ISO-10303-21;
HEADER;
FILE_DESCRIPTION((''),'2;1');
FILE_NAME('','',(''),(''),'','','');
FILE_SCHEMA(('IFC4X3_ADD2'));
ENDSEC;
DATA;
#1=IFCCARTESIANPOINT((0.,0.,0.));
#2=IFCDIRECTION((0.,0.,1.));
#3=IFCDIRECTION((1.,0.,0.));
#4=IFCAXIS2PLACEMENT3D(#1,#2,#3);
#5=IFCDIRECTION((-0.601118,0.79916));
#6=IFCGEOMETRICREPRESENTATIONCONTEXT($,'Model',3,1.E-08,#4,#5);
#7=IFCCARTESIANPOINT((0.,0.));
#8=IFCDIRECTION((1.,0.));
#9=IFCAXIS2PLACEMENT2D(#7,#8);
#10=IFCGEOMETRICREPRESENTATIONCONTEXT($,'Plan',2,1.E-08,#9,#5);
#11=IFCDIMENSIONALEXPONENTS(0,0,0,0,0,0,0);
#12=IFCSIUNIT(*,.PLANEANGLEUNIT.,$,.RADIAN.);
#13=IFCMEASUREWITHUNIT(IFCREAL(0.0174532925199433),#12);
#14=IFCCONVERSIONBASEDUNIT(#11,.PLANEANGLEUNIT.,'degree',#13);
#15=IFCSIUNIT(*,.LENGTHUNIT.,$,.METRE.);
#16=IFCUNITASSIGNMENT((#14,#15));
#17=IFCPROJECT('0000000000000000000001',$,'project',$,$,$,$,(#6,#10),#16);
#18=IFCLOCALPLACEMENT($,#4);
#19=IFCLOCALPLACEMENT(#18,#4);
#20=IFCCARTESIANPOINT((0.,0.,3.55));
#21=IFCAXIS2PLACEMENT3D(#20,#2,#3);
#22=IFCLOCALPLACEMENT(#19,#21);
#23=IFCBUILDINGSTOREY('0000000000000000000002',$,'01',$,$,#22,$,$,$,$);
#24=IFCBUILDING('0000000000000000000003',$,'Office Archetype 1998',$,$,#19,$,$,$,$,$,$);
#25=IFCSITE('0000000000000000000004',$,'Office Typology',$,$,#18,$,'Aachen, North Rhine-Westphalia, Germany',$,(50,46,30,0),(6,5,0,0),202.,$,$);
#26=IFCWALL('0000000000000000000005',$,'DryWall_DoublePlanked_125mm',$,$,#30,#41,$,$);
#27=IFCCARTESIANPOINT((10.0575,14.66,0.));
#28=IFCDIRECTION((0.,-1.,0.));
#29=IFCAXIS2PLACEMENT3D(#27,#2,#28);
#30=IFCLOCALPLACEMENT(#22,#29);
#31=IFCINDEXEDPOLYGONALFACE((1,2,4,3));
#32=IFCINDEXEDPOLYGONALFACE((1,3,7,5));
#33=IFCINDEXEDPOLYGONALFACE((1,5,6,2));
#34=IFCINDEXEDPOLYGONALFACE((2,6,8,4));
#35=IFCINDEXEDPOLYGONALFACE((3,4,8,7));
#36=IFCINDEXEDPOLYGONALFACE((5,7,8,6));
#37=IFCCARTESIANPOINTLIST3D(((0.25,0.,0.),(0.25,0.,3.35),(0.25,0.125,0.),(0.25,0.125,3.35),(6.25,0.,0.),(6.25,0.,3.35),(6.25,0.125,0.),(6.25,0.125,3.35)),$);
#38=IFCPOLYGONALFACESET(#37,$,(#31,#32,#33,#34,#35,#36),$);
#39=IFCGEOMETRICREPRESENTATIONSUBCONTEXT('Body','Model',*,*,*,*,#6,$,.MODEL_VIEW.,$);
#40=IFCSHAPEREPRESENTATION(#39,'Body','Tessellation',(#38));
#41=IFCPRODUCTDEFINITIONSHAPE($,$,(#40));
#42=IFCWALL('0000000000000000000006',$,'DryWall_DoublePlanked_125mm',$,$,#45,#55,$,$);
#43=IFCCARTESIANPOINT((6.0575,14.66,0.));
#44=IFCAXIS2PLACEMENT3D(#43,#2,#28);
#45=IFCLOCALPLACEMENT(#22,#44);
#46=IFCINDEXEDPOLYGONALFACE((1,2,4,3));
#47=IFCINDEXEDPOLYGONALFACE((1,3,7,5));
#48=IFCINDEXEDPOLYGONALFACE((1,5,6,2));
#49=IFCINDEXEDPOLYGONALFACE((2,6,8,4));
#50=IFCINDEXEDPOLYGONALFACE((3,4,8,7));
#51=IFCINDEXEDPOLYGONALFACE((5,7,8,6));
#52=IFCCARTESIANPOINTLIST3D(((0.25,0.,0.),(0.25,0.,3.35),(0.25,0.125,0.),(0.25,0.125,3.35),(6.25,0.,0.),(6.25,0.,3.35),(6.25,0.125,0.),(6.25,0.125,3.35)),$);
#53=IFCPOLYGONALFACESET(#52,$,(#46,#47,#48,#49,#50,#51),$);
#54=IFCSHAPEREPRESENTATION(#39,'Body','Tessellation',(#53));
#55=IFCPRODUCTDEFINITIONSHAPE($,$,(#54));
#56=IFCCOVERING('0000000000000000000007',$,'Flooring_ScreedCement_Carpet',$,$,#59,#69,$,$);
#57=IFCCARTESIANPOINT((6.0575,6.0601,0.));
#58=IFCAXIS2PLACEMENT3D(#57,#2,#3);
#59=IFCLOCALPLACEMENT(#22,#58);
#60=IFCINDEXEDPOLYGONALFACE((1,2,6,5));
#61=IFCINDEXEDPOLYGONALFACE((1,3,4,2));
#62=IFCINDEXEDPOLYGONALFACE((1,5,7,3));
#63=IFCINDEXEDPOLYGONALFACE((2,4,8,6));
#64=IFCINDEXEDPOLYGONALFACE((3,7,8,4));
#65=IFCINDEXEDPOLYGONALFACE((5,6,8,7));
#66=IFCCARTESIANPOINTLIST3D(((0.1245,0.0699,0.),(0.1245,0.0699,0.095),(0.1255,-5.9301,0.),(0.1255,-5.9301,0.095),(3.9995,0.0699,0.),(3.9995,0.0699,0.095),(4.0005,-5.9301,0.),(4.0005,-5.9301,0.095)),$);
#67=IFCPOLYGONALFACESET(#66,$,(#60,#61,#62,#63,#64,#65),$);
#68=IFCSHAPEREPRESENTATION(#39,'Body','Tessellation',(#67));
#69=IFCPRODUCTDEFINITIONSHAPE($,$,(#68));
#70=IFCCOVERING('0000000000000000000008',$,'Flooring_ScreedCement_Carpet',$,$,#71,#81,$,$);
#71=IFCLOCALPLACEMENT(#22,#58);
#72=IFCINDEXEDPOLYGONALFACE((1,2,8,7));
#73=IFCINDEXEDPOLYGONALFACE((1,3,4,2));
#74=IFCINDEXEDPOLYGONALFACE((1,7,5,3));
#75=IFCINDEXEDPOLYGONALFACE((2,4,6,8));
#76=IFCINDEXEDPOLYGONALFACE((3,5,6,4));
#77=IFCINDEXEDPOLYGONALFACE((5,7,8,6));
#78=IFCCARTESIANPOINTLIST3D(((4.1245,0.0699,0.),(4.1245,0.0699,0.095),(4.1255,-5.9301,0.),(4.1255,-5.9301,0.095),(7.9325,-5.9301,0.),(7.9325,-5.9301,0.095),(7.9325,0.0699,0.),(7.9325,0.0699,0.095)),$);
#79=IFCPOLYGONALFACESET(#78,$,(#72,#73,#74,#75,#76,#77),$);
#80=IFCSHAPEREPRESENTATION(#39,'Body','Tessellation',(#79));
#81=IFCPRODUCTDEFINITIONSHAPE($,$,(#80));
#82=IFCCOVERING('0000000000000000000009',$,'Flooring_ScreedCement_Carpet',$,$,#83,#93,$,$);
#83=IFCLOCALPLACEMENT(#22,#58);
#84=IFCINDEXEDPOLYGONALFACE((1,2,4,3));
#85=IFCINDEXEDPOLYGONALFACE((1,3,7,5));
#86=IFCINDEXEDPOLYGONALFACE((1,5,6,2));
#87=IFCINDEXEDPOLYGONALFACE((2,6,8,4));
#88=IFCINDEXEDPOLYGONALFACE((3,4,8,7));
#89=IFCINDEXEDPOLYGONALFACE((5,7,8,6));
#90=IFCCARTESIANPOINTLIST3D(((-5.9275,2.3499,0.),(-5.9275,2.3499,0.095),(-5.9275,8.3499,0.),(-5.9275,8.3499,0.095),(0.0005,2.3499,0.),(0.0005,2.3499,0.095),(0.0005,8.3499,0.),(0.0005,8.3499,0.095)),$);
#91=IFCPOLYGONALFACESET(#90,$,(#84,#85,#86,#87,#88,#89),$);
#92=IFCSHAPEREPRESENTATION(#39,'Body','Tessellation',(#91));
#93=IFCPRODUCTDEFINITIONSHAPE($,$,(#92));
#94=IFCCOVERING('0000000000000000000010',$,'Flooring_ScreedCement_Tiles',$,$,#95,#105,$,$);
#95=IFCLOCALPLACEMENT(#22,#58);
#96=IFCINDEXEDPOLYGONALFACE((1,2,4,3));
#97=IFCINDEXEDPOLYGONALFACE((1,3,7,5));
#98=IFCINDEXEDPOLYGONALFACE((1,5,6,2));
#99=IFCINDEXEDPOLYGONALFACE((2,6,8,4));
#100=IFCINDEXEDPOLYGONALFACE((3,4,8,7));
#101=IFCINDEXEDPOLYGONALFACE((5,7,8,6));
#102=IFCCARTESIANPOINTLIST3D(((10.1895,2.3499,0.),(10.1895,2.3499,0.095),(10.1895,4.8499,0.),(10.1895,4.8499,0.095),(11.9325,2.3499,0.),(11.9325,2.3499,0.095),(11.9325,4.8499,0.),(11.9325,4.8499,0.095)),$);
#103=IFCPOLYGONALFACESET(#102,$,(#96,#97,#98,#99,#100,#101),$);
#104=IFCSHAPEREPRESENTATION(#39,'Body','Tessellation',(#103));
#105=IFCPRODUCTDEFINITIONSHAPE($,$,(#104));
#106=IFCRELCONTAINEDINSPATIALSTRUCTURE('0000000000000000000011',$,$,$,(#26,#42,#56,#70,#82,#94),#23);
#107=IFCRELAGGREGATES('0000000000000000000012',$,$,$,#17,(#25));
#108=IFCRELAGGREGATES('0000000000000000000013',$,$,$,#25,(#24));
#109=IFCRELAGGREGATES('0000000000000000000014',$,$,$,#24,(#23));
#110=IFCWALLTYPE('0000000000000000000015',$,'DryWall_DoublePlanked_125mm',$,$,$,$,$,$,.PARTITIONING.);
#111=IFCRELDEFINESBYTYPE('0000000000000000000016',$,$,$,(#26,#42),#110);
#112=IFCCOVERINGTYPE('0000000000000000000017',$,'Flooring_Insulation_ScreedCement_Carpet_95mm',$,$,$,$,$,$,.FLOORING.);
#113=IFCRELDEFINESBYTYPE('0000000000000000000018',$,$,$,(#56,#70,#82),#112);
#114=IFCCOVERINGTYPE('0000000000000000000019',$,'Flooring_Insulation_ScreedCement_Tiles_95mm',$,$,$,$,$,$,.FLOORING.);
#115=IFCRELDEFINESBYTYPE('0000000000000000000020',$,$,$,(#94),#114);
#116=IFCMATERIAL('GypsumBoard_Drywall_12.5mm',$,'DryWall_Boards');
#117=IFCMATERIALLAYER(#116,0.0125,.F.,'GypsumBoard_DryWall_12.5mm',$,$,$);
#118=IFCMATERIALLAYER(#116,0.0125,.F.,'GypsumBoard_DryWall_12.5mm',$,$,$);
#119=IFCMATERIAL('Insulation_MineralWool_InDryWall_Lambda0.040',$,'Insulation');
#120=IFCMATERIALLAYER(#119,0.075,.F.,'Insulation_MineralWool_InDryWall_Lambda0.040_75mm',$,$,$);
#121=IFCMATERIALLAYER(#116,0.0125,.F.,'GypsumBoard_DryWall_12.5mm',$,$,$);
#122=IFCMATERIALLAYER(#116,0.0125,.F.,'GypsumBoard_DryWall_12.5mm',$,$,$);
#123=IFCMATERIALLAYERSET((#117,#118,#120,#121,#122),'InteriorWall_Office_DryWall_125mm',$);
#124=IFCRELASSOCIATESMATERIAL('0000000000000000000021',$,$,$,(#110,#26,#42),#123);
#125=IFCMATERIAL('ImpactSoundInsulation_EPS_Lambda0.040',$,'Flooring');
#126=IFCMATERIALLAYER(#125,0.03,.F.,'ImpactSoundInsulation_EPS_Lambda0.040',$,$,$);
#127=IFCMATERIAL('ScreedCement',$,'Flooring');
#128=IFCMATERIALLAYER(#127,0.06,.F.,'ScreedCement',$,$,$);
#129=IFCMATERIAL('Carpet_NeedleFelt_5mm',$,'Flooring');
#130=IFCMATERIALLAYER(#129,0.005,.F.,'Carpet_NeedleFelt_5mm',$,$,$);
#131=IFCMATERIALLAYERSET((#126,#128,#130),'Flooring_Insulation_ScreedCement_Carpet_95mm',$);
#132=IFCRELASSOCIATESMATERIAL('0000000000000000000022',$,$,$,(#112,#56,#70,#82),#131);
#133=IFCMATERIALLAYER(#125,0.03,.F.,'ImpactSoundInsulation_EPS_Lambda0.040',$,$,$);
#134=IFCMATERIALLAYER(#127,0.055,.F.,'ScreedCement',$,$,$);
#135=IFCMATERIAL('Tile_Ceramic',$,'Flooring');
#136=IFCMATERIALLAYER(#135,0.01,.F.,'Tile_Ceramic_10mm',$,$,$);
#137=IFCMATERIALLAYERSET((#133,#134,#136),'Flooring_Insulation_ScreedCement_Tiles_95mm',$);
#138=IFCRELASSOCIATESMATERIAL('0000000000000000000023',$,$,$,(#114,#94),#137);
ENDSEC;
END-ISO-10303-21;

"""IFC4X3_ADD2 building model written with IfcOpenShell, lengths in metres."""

from ifc_helpers import new_model, entity, si_unit, converted_unit, direction, frame, origin_with_axes, origin_2d_with_axis, place, context, subcontext, project, spatial, line, indexed_curve, outline, extrude, material, layer, layer_set, layer_usage, type_object, element, save


model = new_model("IFC4X3_ADD2")

# Units and contexts
model_context = context("Model", 3, precision=1e-08, world=origin_with_axes(), true_north=direction((-0.601118, 0.79916)))
plan_context = context("Plan", 2, precision=1e-08, world=origin_2d_with_axis(), true_north=direction((-0.601118, 0.79916)))
body_context = subcontext(model_context, "Body", "Model", "MODEL_VIEW")
ifc_project = project(units=[converted_unit("PLANEANGLEUNIT", "degree", entity("IfcReal", 0.0174532925199433), si_unit("PLANEANGLEUNIT", "RADIAN"), dimensions=[0, 0, 0, 0, 0, 0, 0]), si_unit("LENGTHUNIT", "METRE")], contexts=[model_context, plan_context])

# Site, building, storey
site_placement = place(None, origin_with_axes())
site = spatial("IfcSite", under=ifc_project, at=site_placement, Name="Office Typology", LongName="Aachen, North Rhine-Westphalia, Germany", RefLatitude=(50, 46, 30, 0), RefLongitude=(6, 5, 0, 0), RefElevation=202.0)
building_placement = place(site_placement, origin_with_axes())
building = spatial("IfcBuilding", under=site, at=building_placement, Name="Office Archetype 1998")
storey_placement = place(building_placement, frame((0.0, 0.0, 3.55), z_axis=(0.0, 0.0, 1.0), x_axis=(1.0, 0.0, 0.0)))
storey = spatial("IfcBuildingStorey", under=building, at=storey_placement, Name="01")

# Walls
ifc_material_1 = material(Name="GypsumBoard_Drywall_12.5mm", Category="DryWall_Boards")
ifc_layer_1 = layer(ifc_material_1, 0.0125, ventilated=False, Name="GypsumBoard_DryWall_12.5mm")
ifc_layer_2 = layer(ifc_material_1, 0.0125, ventilated=False, Name="GypsumBoard_DryWall_12.5mm")
ifc_material_2 = material(Name="Insulation_MineralWool_InDryWall_Lambda0.040", Category="Insulation")
ifc_layer_3 = layer(ifc_material_2, 0.075, ventilated=False, Name="Insulation_MineralWool_InDryWall_Lambda0.040_75mm")
ifc_layer_4 = layer(ifc_material_1, 0.0125, ventilated=False, Name="GypsumBoard_DryWall_12.5mm")
ifc_layer_5 = layer(ifc_material_1, 0.0125, ventilated=False, Name="GypsumBoard_DryWall_12.5mm")
ifc_layer_set_1 = layer_set([ifc_layer_1, ifc_layer_2, ifc_layer_3, ifc_layer_4, ifc_layer_5], Name="InteriorWall_Office_DryWall_125mm")
ifc_layer_usage_1 = layer_usage(ifc_layer_set_1, "AXIS2", "POSITIVE", 0.0)
wall_type_1 = type_object("IfcWallType", Name="DryWall_DoublePlanked_125mm", PredefinedType="PARTITIONING", material=ifc_layer_set_1)
wall_1_placement = place(storey_placement, frame((10.0575, 14.66, 0.0), z_axis=(0.0, 0.0, 1.0), x_axis=(0.0, -1.0, 0.0)))
element("IfcWall", 1, at=wall_1_placement, inside=storey, type_object=wall_type_1, material=ifc_layer_usage_1, Name="DryWall_DoublePlanked_125mm", context=body_context, shape_type="SweptSolid", body=[
    extrude(outline(indexed_curve([(0.25, 0.0), (0.25, 0.125), (6.25, 0.125), (6.25, 0.0)], segments=[line(1, 2, 3, 4, 1)])), origin_with_axes(), (0.0, 0.0, 1.0), 3.35),
])
ifc_layer_usage_2 = layer_usage(ifc_layer_set_1, "AXIS2", "POSITIVE", 0.0)
wall_2_placement = place(storey_placement, frame((6.0575, 14.66, 0.0), z_axis=(0.0, 0.0, 1.0), x_axis=(0.0, -1.0, 0.0)))
element("IfcWall", 2, at=wall_2_placement, inside=storey, type_object=wall_type_1, material=ifc_layer_usage_2, Name="DryWall_DoublePlanked_125mm", context=body_context, shape_type="SweptSolid", body=[
    extrude(outline(indexed_curve([(0.25, 0.0), (0.25, 0.125), (6.25, 0.125), (6.25, 0.0)], segments=[line(1, 2, 3, 4, 1)])), origin_with_axes(), (0.0, 0.0, 1.0), 3.35),
])

# Coverings
ifc_material_3 = material(Name="ImpactSoundInsulation_EPS_Lambda0.040", Category="Flooring")
ifc_layer_6 = layer(ifc_material_3, 0.03, ventilated=False, Name="ImpactSoundInsulation_EPS_Lambda0.040")
ifc_material_4 = material(Name="ScreedCement", Category="Flooring")
ifc_layer_7 = layer(ifc_material_4, 0.06, ventilated=False, Name="ScreedCement")
ifc_material_5 = material(Name="Carpet_NeedleFelt_5mm", Category="Flooring")
ifc_layer_8 = layer(ifc_material_5, 0.005, ventilated=False, Name="Carpet_NeedleFelt_5mm")
ifc_layer_set_2 = layer_set([ifc_layer_6, ifc_layer_7, ifc_layer_8], Name="Flooring_Insulation_ScreedCement_Carpet_95mm")
ifc_layer_usage_3 = layer_usage(ifc_layer_set_2, "AXIS3", "POSITIVE", 0.0)
covering_type_1 = type_object("IfcCoveringType", Name="Flooring_Insulation_ScreedCement_Carpet_95mm", PredefinedType="FLOORING", material=ifc_layer_set_2)
covering_1_placement = place(storey_placement, frame((6.0575, 6.0601, 0.0), z_axis=(0.0, 0.0, 1.0), x_axis=(1.0, 0.0, 0.0)))
element("IfcCovering", 3, at=covering_1_placement, inside=storey, type_object=covering_type_1, material=ifc_layer_usage_3, Name="Flooring_ScreedCement_Carpet", context=body_context, shape_type="SweptSolid", body=[
    extrude(outline(indexed_curve([(0.1255, -5.9301), (0.1245, 0.0699), (3.9995, 0.0699), (4.0005, -5.9301)], segments=[line(1, 2, 3, 4, 1)])), origin_with_axes(), (0.0, 0.0, 1.0), 0.095),
])
ifc_layer_usage_4 = layer_usage(ifc_layer_set_2, "AXIS3", "POSITIVE", 0.0)
covering_2_placement = place(storey_placement, frame((6.0575, 6.0601, 0.0), z_axis=(0.0, 0.0, 1.0), x_axis=(1.0, 0.0, 0.0)))
element("IfcCovering", 4, at=covering_2_placement, inside=storey, type_object=covering_type_1, material=ifc_layer_usage_4, Name="Flooring_ScreedCement_Carpet", context=body_context, shape_type="SweptSolid", body=[
    extrude(outline(indexed_curve([(4.1245, 0.0699), (7.9325, 0.0699), (7.9325, -5.9301), (4.1255, -5.9301)], segments=[line(1, 2, 3, 4, 1)])), origin_with_axes(), (0.0, 0.0, 1.0), 0.095),
])
ifc_layer_usage_5 = layer_usage(ifc_layer_set_2, "AXIS3", "POSITIVE", 0.0)
covering_3_placement = place(storey_placement, frame((6.0575, 6.0601, 0.0), z_axis=(0.0, 0.0, 1.0), x_axis=(1.0, 0.0, 0.0)))
element("IfcCovering", 5, at=covering_3_placement, inside=storey, type_object=covering_type_1, material=ifc_layer_usage_5, Name="Flooring_ScreedCement_Carpet", context=body_context, shape_type="SweptSolid", body=[
    extrude(outline(indexed_curve([(-5.9275, 2.3499), (-5.9275, 8.3499), (0.0005, 8.3499), (0.0005, 2.3499)], segments=[line(1, 2, 3, 4, 1)])), origin_with_axes(), (0.0, 0.0, 1.0), 0.095),
])
ifc_layer_9 = layer(ifc_material_3, 0.03, ventilated=False, Name="ImpactSoundInsulation_EPS_Lambda0.040")
ifc_layer_10 = layer(ifc_material_4, 0.055, ventilated=False, Name="ScreedCement")
ifc_material_6 = material(Name="Tile_Ceramic", Category="Flooring")
ifc_layer_11 = layer(ifc_material_6, 0.01, ventilated=False, Name="Tile_Ceramic_10mm")
ifc_layer_set_3 = layer_set([ifc_layer_9, ifc_layer_10, ifc_layer_11], Name="Flooring_Insulation_ScreedCement_Tiles_95mm")
ifc_layer_usage_6 = layer_usage(ifc_layer_set_3, "AXIS3", "POSITIVE", 0.0)
covering_type_2 = type_object("IfcCoveringType", Name="Flooring_Insulation_ScreedCement_Tiles_95mm", PredefinedType="FLOORING", material=ifc_layer_set_3)
covering_4_placement = place(storey_placement, frame((6.0575, 6.0601, 0.0), z_axis=(0.0, 0.0, 1.0), x_axis=(1.0, 0.0, 0.0)))
element("IfcCovering", 6, at=covering_4_placement, inside=storey, type_object=covering_type_2, material=ifc_layer_usage_6, Name="Flooring_ScreedCement_Tiles", context=body_context, shape_type="SweptSolid", body=[
    extrude(outline(indexed_curve([(11.9325, 4.8499), (11.9325, 2.3499), (10.1895, 2.3499), (10.1895, 4.8499)], segments=[line(1, 2, 3, 4, 1)])), None, (0.0, 0.0, 1.0), 0.095),
])

save(model, "model.ifc")
